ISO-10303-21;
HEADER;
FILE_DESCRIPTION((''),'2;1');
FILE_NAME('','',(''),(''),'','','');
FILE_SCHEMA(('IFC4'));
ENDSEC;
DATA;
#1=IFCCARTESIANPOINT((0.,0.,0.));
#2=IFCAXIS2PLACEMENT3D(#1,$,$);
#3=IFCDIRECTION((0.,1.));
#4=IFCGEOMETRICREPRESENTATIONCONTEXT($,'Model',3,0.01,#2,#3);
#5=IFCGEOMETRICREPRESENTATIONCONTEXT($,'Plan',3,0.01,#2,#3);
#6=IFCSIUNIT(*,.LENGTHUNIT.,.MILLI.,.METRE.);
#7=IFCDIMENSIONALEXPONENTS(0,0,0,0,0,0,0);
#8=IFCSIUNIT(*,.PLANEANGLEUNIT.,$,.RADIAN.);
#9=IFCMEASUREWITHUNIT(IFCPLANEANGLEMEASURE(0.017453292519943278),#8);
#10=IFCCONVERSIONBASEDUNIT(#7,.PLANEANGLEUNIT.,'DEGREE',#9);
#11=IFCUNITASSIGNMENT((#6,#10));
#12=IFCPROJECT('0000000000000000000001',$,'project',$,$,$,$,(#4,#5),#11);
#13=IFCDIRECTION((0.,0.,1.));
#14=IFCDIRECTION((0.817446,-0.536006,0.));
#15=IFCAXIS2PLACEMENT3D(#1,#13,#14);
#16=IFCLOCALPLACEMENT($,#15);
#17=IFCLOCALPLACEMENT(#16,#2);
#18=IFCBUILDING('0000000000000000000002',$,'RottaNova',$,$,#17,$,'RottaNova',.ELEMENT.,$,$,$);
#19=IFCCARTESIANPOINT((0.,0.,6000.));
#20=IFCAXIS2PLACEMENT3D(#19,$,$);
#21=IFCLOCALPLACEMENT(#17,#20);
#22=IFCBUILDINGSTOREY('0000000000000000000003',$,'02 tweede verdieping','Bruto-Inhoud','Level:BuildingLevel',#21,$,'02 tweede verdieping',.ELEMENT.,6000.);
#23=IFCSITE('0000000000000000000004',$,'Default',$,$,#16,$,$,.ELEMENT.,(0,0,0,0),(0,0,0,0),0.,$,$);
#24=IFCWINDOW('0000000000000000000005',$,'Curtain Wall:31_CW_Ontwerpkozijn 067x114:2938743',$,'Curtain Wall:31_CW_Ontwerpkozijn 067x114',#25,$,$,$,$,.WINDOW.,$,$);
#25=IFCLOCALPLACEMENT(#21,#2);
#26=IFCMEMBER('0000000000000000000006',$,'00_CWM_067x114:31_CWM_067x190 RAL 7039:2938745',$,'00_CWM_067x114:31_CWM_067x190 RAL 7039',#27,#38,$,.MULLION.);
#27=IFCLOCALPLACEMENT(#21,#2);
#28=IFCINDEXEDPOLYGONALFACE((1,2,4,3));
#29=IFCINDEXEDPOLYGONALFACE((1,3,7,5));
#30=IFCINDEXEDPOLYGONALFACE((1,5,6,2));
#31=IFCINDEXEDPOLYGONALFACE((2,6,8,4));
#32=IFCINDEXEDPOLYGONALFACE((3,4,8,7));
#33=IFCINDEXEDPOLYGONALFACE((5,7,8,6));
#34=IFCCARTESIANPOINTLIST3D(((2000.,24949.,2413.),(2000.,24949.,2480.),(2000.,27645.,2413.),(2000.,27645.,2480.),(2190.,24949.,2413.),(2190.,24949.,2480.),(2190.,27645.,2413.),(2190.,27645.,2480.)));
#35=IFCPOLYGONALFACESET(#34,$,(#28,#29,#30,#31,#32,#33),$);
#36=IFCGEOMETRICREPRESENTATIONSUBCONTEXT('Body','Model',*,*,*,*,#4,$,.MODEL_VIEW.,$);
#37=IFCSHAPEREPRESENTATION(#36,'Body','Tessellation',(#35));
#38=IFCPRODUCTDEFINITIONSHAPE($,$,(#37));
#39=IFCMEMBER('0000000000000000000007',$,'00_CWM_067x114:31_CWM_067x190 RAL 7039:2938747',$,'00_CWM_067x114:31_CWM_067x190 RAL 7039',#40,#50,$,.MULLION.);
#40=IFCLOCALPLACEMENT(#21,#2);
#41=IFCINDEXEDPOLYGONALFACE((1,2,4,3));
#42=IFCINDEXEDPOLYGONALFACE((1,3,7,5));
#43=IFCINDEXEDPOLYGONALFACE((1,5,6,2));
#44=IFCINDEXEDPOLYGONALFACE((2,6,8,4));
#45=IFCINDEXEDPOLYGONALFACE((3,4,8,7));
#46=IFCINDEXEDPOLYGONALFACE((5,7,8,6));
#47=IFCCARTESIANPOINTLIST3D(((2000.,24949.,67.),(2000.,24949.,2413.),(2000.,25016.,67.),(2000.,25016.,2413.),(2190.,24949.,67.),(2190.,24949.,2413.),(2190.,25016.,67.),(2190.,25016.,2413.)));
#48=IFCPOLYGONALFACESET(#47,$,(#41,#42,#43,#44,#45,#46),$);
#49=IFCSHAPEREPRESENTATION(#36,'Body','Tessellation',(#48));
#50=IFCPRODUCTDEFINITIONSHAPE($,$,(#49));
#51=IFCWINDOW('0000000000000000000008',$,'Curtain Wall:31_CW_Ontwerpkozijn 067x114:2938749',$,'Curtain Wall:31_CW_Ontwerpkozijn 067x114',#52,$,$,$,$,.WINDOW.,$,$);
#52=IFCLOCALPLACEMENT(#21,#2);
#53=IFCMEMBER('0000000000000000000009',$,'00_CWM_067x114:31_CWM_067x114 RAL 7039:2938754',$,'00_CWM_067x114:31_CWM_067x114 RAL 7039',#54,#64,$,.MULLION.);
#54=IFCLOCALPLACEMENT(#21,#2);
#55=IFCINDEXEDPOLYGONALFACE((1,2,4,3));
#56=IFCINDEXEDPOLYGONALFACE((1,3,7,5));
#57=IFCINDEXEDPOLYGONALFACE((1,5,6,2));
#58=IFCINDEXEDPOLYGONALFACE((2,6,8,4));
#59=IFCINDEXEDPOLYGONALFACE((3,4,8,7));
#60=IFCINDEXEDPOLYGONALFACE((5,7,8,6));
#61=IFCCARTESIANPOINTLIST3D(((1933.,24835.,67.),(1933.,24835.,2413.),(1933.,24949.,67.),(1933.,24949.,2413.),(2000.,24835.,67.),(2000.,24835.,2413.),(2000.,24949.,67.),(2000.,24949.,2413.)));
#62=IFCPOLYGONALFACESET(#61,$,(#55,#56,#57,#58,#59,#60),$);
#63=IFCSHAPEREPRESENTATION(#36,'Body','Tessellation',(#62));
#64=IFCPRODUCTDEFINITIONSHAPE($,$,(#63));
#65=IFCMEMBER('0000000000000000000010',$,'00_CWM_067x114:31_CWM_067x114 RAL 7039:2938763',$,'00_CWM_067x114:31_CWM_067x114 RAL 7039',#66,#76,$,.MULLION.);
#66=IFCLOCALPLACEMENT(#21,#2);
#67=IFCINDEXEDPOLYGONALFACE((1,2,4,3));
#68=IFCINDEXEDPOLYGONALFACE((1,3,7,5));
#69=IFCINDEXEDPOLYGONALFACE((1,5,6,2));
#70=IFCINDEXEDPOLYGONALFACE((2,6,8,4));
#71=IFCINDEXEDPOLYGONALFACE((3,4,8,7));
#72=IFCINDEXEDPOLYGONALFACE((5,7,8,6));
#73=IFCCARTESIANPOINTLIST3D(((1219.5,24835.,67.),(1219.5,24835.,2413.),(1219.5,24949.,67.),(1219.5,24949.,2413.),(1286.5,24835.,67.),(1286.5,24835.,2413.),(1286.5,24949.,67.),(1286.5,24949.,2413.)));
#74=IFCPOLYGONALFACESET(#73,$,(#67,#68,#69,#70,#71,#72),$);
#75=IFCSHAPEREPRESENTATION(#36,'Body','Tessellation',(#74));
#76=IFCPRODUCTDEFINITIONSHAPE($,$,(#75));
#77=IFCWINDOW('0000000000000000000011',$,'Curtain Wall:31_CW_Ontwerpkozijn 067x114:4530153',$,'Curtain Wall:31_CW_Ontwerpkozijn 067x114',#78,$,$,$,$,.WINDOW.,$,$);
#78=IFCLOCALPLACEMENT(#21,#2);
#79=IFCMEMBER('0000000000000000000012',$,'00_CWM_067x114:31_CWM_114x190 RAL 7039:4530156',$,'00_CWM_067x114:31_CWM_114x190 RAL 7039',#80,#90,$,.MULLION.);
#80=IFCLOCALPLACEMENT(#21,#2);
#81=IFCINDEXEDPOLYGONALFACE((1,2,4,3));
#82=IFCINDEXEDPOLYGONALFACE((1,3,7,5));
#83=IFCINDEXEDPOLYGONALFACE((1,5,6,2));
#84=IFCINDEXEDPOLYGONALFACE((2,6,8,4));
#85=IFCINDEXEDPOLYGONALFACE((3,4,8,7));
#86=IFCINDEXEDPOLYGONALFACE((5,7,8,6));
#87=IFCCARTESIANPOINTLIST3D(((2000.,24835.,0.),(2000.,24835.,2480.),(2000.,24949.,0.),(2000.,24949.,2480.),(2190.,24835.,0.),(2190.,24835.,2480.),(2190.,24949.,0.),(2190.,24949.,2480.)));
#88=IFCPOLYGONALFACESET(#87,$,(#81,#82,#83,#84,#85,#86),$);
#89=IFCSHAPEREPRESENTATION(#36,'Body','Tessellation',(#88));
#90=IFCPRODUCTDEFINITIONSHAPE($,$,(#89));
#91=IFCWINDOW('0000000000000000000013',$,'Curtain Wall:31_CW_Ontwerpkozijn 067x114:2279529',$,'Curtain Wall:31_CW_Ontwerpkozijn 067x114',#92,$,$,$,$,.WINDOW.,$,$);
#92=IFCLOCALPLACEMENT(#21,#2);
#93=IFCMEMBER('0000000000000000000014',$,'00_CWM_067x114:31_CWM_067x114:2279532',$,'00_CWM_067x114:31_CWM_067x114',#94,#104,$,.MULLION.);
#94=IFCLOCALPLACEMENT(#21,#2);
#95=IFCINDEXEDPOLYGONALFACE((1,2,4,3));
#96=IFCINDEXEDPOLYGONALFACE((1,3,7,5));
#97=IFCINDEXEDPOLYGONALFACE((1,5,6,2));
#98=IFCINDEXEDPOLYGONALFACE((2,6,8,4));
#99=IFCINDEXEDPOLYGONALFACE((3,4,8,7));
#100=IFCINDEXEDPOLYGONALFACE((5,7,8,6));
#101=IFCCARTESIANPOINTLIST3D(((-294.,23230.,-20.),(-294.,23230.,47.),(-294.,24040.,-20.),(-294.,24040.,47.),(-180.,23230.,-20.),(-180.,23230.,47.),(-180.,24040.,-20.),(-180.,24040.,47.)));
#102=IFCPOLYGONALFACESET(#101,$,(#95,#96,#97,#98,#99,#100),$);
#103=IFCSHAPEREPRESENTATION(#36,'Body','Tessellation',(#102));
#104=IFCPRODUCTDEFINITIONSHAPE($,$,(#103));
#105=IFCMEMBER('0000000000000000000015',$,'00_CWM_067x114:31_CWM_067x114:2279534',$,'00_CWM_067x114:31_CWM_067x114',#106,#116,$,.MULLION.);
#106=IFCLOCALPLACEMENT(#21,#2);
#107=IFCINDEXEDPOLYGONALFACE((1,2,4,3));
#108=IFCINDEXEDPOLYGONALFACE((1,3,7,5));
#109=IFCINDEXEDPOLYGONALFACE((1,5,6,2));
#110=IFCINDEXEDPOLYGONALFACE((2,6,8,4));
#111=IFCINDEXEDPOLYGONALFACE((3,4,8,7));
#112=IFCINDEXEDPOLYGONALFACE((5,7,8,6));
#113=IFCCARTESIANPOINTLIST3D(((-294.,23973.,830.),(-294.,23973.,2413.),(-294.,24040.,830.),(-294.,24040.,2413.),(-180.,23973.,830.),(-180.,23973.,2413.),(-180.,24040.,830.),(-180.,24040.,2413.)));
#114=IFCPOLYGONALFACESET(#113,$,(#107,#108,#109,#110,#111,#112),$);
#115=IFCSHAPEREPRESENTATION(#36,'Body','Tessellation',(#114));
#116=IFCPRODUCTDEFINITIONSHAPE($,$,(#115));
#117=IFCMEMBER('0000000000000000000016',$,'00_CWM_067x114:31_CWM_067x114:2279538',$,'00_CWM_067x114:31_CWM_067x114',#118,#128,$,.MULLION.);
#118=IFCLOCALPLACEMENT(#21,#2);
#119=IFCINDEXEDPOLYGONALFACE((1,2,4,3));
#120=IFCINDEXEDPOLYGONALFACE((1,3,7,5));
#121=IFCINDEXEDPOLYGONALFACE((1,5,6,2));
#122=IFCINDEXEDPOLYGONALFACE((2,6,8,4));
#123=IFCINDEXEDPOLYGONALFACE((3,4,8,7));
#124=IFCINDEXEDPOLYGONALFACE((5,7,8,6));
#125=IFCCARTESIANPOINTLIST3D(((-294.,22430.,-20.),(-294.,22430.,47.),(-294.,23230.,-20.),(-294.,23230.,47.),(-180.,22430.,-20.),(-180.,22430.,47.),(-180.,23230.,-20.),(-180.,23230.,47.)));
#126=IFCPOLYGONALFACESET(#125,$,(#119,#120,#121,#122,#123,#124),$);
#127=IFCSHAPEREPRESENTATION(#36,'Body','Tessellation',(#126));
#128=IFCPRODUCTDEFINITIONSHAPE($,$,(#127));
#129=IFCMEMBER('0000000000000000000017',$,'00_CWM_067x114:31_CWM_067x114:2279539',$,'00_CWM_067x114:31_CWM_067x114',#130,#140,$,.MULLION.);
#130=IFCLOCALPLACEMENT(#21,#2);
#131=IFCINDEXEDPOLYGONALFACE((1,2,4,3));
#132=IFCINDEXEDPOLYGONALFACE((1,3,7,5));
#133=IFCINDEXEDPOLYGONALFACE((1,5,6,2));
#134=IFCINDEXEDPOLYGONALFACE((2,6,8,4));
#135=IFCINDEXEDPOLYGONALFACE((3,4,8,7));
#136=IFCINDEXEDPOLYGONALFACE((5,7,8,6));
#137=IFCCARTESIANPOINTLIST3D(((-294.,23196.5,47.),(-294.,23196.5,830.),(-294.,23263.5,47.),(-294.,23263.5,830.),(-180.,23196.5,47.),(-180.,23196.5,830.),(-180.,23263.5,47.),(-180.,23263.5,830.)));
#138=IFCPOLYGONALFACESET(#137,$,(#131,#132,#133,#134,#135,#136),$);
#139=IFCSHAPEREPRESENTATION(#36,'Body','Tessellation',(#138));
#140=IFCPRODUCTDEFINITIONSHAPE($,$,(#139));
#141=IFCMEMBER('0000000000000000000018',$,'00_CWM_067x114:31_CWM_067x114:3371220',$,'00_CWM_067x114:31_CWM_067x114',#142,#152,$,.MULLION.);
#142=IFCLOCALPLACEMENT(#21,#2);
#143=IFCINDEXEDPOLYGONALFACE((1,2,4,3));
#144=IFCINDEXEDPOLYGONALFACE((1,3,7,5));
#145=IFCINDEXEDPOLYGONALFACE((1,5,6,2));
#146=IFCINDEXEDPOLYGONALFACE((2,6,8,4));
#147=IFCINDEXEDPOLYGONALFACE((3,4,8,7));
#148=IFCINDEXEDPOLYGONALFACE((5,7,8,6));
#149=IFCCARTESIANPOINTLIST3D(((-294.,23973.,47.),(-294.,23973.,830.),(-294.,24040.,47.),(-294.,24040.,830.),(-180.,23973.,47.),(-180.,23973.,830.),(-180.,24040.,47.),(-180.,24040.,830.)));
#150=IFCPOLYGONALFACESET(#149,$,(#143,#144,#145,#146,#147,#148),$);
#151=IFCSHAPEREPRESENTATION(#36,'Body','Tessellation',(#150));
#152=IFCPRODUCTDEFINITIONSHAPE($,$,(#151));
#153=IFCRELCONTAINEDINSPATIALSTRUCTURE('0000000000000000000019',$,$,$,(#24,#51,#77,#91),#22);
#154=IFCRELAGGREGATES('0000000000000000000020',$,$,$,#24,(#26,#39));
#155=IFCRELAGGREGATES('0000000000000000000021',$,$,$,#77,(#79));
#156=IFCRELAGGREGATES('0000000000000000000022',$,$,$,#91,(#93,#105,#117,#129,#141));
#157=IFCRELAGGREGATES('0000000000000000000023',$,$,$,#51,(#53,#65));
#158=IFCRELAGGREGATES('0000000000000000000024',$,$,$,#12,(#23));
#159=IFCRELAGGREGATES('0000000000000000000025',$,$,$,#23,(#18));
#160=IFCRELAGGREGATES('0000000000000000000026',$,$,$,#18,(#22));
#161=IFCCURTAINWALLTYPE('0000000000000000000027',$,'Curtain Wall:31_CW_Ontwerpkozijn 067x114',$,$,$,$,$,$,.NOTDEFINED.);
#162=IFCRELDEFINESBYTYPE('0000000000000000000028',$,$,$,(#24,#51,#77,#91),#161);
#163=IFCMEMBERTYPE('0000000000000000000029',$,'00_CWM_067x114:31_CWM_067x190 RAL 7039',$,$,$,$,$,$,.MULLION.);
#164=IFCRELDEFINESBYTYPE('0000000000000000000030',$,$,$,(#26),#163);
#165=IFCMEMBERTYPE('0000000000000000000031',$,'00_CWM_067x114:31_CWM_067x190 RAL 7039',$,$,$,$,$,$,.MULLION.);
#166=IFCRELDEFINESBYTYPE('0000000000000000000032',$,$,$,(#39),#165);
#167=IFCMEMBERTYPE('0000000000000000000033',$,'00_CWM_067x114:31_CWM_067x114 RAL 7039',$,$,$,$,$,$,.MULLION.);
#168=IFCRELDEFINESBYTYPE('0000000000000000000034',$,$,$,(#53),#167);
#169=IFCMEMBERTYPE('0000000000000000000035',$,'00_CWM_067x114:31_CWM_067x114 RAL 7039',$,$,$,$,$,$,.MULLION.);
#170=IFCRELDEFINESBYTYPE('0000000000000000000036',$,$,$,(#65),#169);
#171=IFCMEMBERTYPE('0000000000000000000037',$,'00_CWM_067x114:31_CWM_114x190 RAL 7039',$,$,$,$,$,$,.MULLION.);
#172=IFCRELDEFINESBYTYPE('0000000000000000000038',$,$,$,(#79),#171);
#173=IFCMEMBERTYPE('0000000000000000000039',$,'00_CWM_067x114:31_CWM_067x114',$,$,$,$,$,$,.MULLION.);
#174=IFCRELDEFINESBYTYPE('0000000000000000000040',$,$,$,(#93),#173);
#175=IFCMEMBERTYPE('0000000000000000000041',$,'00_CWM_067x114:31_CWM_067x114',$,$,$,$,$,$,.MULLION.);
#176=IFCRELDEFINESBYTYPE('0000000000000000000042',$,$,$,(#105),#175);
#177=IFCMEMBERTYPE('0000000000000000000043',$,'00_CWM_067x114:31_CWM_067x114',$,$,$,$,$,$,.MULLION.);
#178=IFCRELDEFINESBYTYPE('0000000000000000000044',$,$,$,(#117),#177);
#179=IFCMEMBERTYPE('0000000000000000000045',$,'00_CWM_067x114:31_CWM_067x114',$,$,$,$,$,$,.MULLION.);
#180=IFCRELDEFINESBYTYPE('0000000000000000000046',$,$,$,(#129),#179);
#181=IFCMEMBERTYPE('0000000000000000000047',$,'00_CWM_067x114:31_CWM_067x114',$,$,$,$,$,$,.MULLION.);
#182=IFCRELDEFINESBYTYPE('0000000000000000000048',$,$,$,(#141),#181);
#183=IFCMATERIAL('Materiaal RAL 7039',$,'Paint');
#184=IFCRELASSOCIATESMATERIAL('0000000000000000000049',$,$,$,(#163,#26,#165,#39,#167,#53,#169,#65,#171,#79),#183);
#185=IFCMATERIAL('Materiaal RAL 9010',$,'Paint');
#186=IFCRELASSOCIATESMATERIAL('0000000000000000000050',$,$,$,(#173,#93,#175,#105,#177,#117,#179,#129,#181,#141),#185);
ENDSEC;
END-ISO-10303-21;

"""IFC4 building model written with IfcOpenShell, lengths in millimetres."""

from ifc_helpers import new_model, entity, si_unit, converted_unit, direction, frame, origin, place, context, subcontext, project, spatial, indexed_curve, outline, extrude, source, transform, mapped, material, type_object, type_shapes, element, aggregate, save


model = new_model("IFC4")

# Units and contexts
model_context = context("Model", 3, precision=0.01, world=origin(), true_north=direction((0.0, 1.0)))
plan_context = context("Plan", 3, precision=0.01, world=origin(), true_north=direction((0.0, 1.0)))
body_context = subcontext(model_context, "Body", "Model", "MODEL_VIEW")
ifc_project = project(units=[si_unit("LENGTHUNIT", "METRE", prefix="MILLI"), converted_unit("PLANEANGLEUNIT", "DEGREE", entity("IfcPlaneAngleMeasure", 0.017453292519943278), si_unit("PLANEANGLEUNIT", "RADIAN"), dimensions=[0, 0, 0, 0, 0, 0, 0])], contexts=[model_context, plan_context])

# Site, building, storey
site_placement = place(None, frame((0.0, 0.0, 0.0), z_axis=(0.0, 0.0, 1.0), x_axis=(0.817446, -0.536006, 0.0)))
site = spatial("IfcSite", under=ifc_project, at=site_placement, Name="Default", CompositionType="ELEMENT", RefLatitude=(0, 0, 0, 0), RefLongitude=(0, 0, 0, 0), RefElevation=0.0)
building_placement = place(site_placement, origin())
building = spatial("IfcBuilding", under=site, at=building_placement, Name="RottaNova", LongName="RottaNova", CompositionType="ELEMENT")
storey_placement = place(building_placement, frame((0.0, 0.0, 6000.0)))
storey = spatial("IfcBuildingStorey", under=building, at=storey_placement, Name="02 tweede verdieping", Description="Bruto-Inhoud", ObjectType="Level:BuildingLevel", LongName="02 tweede verdieping", CompositionType="ELEMENT", Elevation=6000.0)

# Windows, members
curtain_wall_type = type_object("IfcCurtainWallType", Name="Curtain Wall:31_CW_Ontwerpkozijn 067x114", PredefinedType="NOTDEFINED")
window_1_placement = place(storey_placement, frame((0.0, 0.0, -6000.0)))
window_1 = element("IfcWindow", 1, at=window_1_placement, inside=storey, type_object=curtain_wall_type, Name="Curtain Wall:31_CW_Ontwerpkozijn 067x114:2938743", ObjectType="Curtain Wall:31_CW_Ontwerpkozijn 067x114", PredefinedType="WINDOW")
ifc_material_1 = material(Name="Materiaal RAL 7039", Category="Paint")
member_type_1 = type_object("IfcMemberType", Name="00_CWM_067x114:31_CWM_067x190 RAL 7039", PredefinedType="MULLION", material=ifc_material_1)
shared_shape_1 = source(origin(), body_context, "Body", "SweptSolid", [
    extrude(outline(indexed_curve([(-33.5, -95.0), (33.5, -95.0), (33.5, 95.0), (-33.5, 95.0), (-33.5, -95.0)], self_intersect=False)), frame((-33.5, 95.0, -2696.0), z_axis=(0.0, 0.0, 1.0), x_axis=(-1.0, 0.0, 0.0)), (0.0, 0.0, 1.0), 2696.0),
])
type_shapes(member_type_1, [shared_shape_1])
member_1_placement = place(window_1_placement, frame((2190.0, 24949.0, 8480.0), z_axis=(0.0, -1.0, 0.0), x_axis=(0.0, 0.0, 1.0)))
member_1 = element("IfcMember", 2, at=member_1_placement, type_object=member_type_1, material=ifc_material_1, Name="00_CWM_067x114:31_CWM_067x190 RAL 7039:2938745", ObjectType="00_CWM_067x114:31_CWM_067x190 RAL 7039", PredefinedType="MULLION", context=body_context, shape_type="MappedRepresentation", body=[
    mapped(shared_shape_1, transform((0.0, 0.0, 0.0), scale=1.0)),
])
member_type_2 = type_object("IfcMemberType", Name="00_CWM_067x114:31_CWM_067x190 RAL 7039", PredefinedType="MULLION", material=ifc_material_1)
shared_shape_2 = source(origin(), body_context, "Body", "SweptSolid", [
    extrude(outline(indexed_curve([(-33.5, -95.0), (33.5, -95.0), (33.5, 95.0), (-33.5, 95.0), (-33.5, -95.0)], self_intersect=False)), frame((-33.5, 95.0, -2346.0), z_axis=(0.0, 0.0, 1.0), x_axis=(-1.0, 0.0, 0.0)), (0.0, 0.0, 1.0), 2346.0),
])
type_shapes(member_type_2, [shared_shape_2])
member_2_placement = place(window_1_placement, frame((2190.0, 24949.0, 6067.0), z_axis=(0.0, 0.0, -1.0), x_axis=(0.0, -1.0, 0.0)))
member_2 = element("IfcMember", 3, at=member_2_placement, type_object=member_type_2, material=ifc_material_1, Name="00_CWM_067x114:31_CWM_067x190 RAL 7039:2938747", ObjectType="00_CWM_067x114:31_CWM_067x190 RAL 7039", PredefinedType="MULLION", context=body_context, shape_type="MappedRepresentation", body=[
    mapped(shared_shape_2, transform((0.0, 0.0, 0.0), scale=1.0)),
])
aggregate(window_1, [member_1, member_2])
window_2_placement = place(storey_placement, frame((0.0, 0.0, -6000.0)))
window_2 = element("IfcWindow", 4, at=window_2_placement, inside=storey, type_object=curtain_wall_type, Name="Curtain Wall:31_CW_Ontwerpkozijn 067x114:2938749", ObjectType="Curtain Wall:31_CW_Ontwerpkozijn 067x114", PredefinedType="WINDOW")
member_type_3 = type_object("IfcMemberType", Name="00_CWM_067x114:31_CWM_067x114 RAL 7039", PredefinedType="MULLION", material=ifc_material_1)
shared_shape_3 = source(origin(), body_context, "Body", "SweptSolid", [
    extrude(outline(indexed_curve([(-33.5, -57.0), (33.5, -57.0), (33.5, 57.0), (-33.5, 57.0), (-33.5, -57.0)], self_intersect=False)), frame((-33.5, 57.0, -2346.0), z_axis=(0.0, 0.0, 1.0), x_axis=(-1.0, 0.0, 0.0)), (0.0, 0.0, 1.0), 2346.0),
])
type_shapes(member_type_3, [shared_shape_3])
member_3_placement = place(window_2_placement, frame((2000.0, 24835.0, 8413.0)))
member_3 = element("IfcMember", 5, at=member_3_placement, type_object=member_type_3, material=ifc_material_1, Name="00_CWM_067x114:31_CWM_067x114 RAL 7039:2938754", ObjectType="00_CWM_067x114:31_CWM_067x114 RAL 7039", PredefinedType="MULLION", context=body_context, shape_type="MappedRepresentation", body=[
    mapped(shared_shape_3, transform((0.0, 0.0, 0.0), scale=1.0)),
])
member_type_4 = type_object("IfcMemberType", Name="00_CWM_067x114:31_CWM_067x114 RAL 7039", PredefinedType="MULLION", material=ifc_material_1)
shared_shape_4 = source(origin(), body_context, "Body", "SweptSolid", [
    extrude(outline(indexed_curve([(-33.5, -57.0), (33.5, -57.0), (33.5, 57.0), (-33.5, 57.0), (-33.5, -57.0)], self_intersect=False)), frame((0.0, 57.0, -2346.0), z_axis=(0.0, 0.0, 1.0), x_axis=(-1.0, 0.0, 0.0)), (0.0, 0.0, 1.0), 2346.0),
])
type_shapes(member_type_4, [shared_shape_4])
member_4_placement = place(window_2_placement, frame((1253.0, 24835.0, 6067.0), z_axis=(0.0, 0.0, -1.0), x_axis=(-1.0, 0.0, 0.0)))
member_4 = element("IfcMember", 6, at=member_4_placement, type_object=member_type_4, material=ifc_material_1, Name="00_CWM_067x114:31_CWM_067x114 RAL 7039:2938763", ObjectType="00_CWM_067x114:31_CWM_067x114 RAL 7039", PredefinedType="MULLION", context=body_context, shape_type="MappedRepresentation", body=[
    mapped(shared_shape_4, transform((0.0, 0.0, 0.0), scale=1.0)),
])

# Window, member
window_3_placement = place(storey_placement, frame((0.0, 0.0, -6000.0)))
window_3 = element("IfcWindow", 7, at=window_3_placement, inside=storey, type_object=curtain_wall_type, Name="Curtain Wall:31_CW_Ontwerpkozijn 067x114:4530153", ObjectType="Curtain Wall:31_CW_Ontwerpkozijn 067x114", PredefinedType="WINDOW")
member_type_5 = type_object("IfcMemberType", Name="00_CWM_067x114:31_CWM_114x190 RAL 7039", PredefinedType="MULLION", material=ifc_material_1)
shared_shape_5 = source(origin(), body_context, "Body", "SweptSolid", [
    extrude(outline(indexed_curve([(-57.0, -95.0), (57.0, -95.0), (57.0, 95.0), (-57.0, 95.0), (-57.0, -95.0)], self_intersect=False)), frame((-95.0, 0.0, -2480.0), z_axis=(0.0, 0.0, 1.0), x_axis=(0.0, -1.0, 0.0)), (0.0, 0.0, 1.0), 2480.0),
])
type_shapes(member_type_5, [shared_shape_5])
member_5_placement = place(window_3_placement, frame((2190.0, 24892.0, 8480.0)))
member_5 = element("IfcMember", 8, at=member_5_placement, type_object=member_type_5, material=ifc_material_1, Name="00_CWM_067x114:31_CWM_114x190 RAL 7039:4530156", ObjectType="00_CWM_067x114:31_CWM_114x190 RAL 7039", PredefinedType="MULLION", context=body_context, shape_type="MappedRepresentation", body=[
    mapped(shared_shape_5, transform((0.0, 0.0, 0.0), scale=1.0)),
])
aggregate(window_3, [member_5])

# Window, members
window_4_placement = place(storey_placement, frame((0.0, 0.0, -6000.0)))
window_4 = element("IfcWindow", 9, at=window_4_placement, inside=storey, type_object=curtain_wall_type, Name="Curtain Wall:31_CW_Ontwerpkozijn 067x114:2279529", ObjectType="Curtain Wall:31_CW_Ontwerpkozijn 067x114", PredefinedType="WINDOW")
ifc_material_2 = material(Name="Materiaal RAL 9010", Category="Paint")
member_type_6 = type_object("IfcMemberType", Name="00_CWM_067x114:31_CWM_067x114", PredefinedType="MULLION", material=ifc_material_2)
shared_shape_6 = source(origin(), body_context, "Body", "SweptSolid", [
    extrude(outline(indexed_curve([(-33.5, -57.0), (33.5, -57.0), (33.5, 57.0), (-33.5, 57.0), (-33.5, -57.0)], self_intersect=False)), frame((-33.5, 57.0, -810.0), z_axis=(0.0, 0.0, 1.0), x_axis=(-1.0, 0.0, 0.0)), (0.0, 0.0, 1.0), 810.0),
])
type_shapes(member_type_6, [shared_shape_6])
member_6_placement = place(window_4_placement, frame((-180.0, 24040.0, 5980.0), z_axis=(0.0, 1.0, 0.0), x_axis=(0.0, 0.0, -1.0)))
member_6 = element("IfcMember", 10, at=member_6_placement, type_object=member_type_6, material=ifc_material_2, Name="00_CWM_067x114:31_CWM_067x114:2279532", ObjectType="00_CWM_067x114:31_CWM_067x114", PredefinedType="MULLION", context=body_context, shape_type="MappedRepresentation", body=[
    mapped(shared_shape_6, transform((0.0, 0.0, 0.0), scale=1.0)),
])
member_type_7 = type_object("IfcMemberType", Name="00_CWM_067x114:31_CWM_067x114", PredefinedType="MULLION", material=ifc_material_2)
shared_shape_7 = source(origin(), body_context, "Body", "SweptSolid", [
    extrude(outline(indexed_curve([(-33.5, -57.0), (33.5, -57.0), (33.5, 57.0), (-33.5, 57.0), (-33.5, -57.0)], self_intersect=False)), frame((-33.5, 57.0, -1583.0), z_axis=(0.0, 0.0, 1.0), x_axis=(-1.0, 0.0, 0.0)), (0.0, 0.0, 1.0), 1583.0),
])
type_shapes(member_type_7, [shared_shape_7])
member_7_placement = place(window_4_placement, frame((-180.0, 24040.0, 8413.0), z_axis=(0.0, 0.0, 1.0), x_axis=(0.0, 1.0, 0.0)))
member_7 = element("IfcMember", 11, at=member_7_placement, type_object=member_type_7, material=ifc_material_2, Name="00_CWM_067x114:31_CWM_067x114:2279534", ObjectType="00_CWM_067x114:31_CWM_067x114", PredefinedType="MULLION", context=body_context, shape_type="MappedRepresentation", body=[
    mapped(shared_shape_7, transform((0.0, 0.0, 0.0), scale=1.0)),
])
member_type_8 = type_object("IfcMemberType", Name="00_CWM_067x114:31_CWM_067x114", PredefinedType="MULLION", material=ifc_material_2)
shared_shape_8 = source(origin(), body_context, "Body", "SweptSolid", [
    extrude(outline(indexed_curve([(-33.5, -57.0), (33.5, -57.0), (33.5, 57.0), (-33.5, 57.0), (-33.5, -57.0)], self_intersect=False)), frame((-33.5, 57.0, -800.0), z_axis=(0.0, 0.0, 1.0), x_axis=(-1.0, 0.0, 0.0)), (0.0, 0.0, 1.0), 800.0),
])
type_shapes(member_type_8, [shared_shape_8])
member_8_placement = place(window_4_placement, frame((-180.0, 23230.0, 5980.0), z_axis=(0.0, 1.0, 0.0), x_axis=(0.0, 0.0, -1.0)))
member_8 = element("IfcMember", 12, at=member_8_placement, type_object=member_type_8, material=ifc_material_2, Name="00_CWM_067x114:31_CWM_067x114:2279538", ObjectType="00_CWM_067x114:31_CWM_067x114", PredefinedType="MULLION", context=body_context, shape_type="MappedRepresentation", body=[
    mapped(shared_shape_8, transform((0.0, 0.0, 0.0), scale=1.0)),
])
member_type_9 = type_object("IfcMemberType", Name="00_CWM_067x114:31_CWM_067x114", PredefinedType="MULLION", material=ifc_material_2)
shared_shape_9 = source(origin(), body_context, "Body", "SweptSolid", [
    extrude(outline(indexed_curve([(-33.5, -57.0), (33.5, -57.0), (33.5, 57.0), (-33.5, 57.0), (-33.5, -57.0)], self_intersect=False)), frame((0.0, 57.0, -783.0), z_axis=(0.0, 0.0, 1.0), x_axis=(-1.0, 0.0, 0.0)), (0.0, 0.0, 1.0), 783.0),
])
type_shapes(member_type_9, [shared_shape_9])
member_9_placement = place(window_4_placement, frame((-180.0, 23230.0, 6047.0), z_axis=(0.0, 0.0, -1.0), x_axis=(0.0, -1.0, 0.0)))
member_9 = element("IfcMember", 13, at=member_9_placement, type_object=member_type_9, material=ifc_material_2, Name="00_CWM_067x114:31_CWM_067x114:2279539", ObjectType="00_CWM_067x114:31_CWM_067x114", PredefinedType="MULLION", context=body_context, shape_type="MappedRepresentation", body=[
    mapped(shared_shape_9, transform((0.0, 0.0, 0.0), scale=1.0)),
])
member_type_10 = type_object("IfcMemberType", Name="00_CWM_067x114:31_CWM_067x114", PredefinedType="MULLION", material=ifc_material_2)
shared_shape_10 = source(origin(), body_context, "Body", "SweptSolid", [
    extrude(outline(indexed_curve([(-33.5, -57.0), (33.5, -57.0), (33.5, 57.0), (-33.5, 57.0), (-33.5, -57.0)], self_intersect=False)), frame((-33.5, 57.0, -783.0), z_axis=(0.0, 0.0, 1.0), x_axis=(-1.0, 0.0, 0.0)), (0.0, 0.0, 1.0), 783.0),
])
type_shapes(member_type_10, [shared_shape_10])
member_10_placement = place(window_4_placement, frame((-180.0, 24040.0, 6830.0), z_axis=(0.0, 0.0, 1.0), x_axis=(0.0, 1.0, 0.0)))
member_10 = element("IfcMember", 14, at=member_10_placement, type_object=member_type_10, material=ifc_material_2, Name="00_CWM_067x114:31_CWM_067x114:3371220", ObjectType="00_CWM_067x114:31_CWM_067x114", PredefinedType="MULLION", context=body_context, shape_type="MappedRepresentation", body=[
    mapped(shared_shape_10, transform((0.0, 0.0, 0.0), scale=1.0)),
])

aggregate(window_4, [member_6, member_7, member_8, member_9, member_10])
aggregate(window_2, [member_3, member_4])

save(model, "model.ifc")
